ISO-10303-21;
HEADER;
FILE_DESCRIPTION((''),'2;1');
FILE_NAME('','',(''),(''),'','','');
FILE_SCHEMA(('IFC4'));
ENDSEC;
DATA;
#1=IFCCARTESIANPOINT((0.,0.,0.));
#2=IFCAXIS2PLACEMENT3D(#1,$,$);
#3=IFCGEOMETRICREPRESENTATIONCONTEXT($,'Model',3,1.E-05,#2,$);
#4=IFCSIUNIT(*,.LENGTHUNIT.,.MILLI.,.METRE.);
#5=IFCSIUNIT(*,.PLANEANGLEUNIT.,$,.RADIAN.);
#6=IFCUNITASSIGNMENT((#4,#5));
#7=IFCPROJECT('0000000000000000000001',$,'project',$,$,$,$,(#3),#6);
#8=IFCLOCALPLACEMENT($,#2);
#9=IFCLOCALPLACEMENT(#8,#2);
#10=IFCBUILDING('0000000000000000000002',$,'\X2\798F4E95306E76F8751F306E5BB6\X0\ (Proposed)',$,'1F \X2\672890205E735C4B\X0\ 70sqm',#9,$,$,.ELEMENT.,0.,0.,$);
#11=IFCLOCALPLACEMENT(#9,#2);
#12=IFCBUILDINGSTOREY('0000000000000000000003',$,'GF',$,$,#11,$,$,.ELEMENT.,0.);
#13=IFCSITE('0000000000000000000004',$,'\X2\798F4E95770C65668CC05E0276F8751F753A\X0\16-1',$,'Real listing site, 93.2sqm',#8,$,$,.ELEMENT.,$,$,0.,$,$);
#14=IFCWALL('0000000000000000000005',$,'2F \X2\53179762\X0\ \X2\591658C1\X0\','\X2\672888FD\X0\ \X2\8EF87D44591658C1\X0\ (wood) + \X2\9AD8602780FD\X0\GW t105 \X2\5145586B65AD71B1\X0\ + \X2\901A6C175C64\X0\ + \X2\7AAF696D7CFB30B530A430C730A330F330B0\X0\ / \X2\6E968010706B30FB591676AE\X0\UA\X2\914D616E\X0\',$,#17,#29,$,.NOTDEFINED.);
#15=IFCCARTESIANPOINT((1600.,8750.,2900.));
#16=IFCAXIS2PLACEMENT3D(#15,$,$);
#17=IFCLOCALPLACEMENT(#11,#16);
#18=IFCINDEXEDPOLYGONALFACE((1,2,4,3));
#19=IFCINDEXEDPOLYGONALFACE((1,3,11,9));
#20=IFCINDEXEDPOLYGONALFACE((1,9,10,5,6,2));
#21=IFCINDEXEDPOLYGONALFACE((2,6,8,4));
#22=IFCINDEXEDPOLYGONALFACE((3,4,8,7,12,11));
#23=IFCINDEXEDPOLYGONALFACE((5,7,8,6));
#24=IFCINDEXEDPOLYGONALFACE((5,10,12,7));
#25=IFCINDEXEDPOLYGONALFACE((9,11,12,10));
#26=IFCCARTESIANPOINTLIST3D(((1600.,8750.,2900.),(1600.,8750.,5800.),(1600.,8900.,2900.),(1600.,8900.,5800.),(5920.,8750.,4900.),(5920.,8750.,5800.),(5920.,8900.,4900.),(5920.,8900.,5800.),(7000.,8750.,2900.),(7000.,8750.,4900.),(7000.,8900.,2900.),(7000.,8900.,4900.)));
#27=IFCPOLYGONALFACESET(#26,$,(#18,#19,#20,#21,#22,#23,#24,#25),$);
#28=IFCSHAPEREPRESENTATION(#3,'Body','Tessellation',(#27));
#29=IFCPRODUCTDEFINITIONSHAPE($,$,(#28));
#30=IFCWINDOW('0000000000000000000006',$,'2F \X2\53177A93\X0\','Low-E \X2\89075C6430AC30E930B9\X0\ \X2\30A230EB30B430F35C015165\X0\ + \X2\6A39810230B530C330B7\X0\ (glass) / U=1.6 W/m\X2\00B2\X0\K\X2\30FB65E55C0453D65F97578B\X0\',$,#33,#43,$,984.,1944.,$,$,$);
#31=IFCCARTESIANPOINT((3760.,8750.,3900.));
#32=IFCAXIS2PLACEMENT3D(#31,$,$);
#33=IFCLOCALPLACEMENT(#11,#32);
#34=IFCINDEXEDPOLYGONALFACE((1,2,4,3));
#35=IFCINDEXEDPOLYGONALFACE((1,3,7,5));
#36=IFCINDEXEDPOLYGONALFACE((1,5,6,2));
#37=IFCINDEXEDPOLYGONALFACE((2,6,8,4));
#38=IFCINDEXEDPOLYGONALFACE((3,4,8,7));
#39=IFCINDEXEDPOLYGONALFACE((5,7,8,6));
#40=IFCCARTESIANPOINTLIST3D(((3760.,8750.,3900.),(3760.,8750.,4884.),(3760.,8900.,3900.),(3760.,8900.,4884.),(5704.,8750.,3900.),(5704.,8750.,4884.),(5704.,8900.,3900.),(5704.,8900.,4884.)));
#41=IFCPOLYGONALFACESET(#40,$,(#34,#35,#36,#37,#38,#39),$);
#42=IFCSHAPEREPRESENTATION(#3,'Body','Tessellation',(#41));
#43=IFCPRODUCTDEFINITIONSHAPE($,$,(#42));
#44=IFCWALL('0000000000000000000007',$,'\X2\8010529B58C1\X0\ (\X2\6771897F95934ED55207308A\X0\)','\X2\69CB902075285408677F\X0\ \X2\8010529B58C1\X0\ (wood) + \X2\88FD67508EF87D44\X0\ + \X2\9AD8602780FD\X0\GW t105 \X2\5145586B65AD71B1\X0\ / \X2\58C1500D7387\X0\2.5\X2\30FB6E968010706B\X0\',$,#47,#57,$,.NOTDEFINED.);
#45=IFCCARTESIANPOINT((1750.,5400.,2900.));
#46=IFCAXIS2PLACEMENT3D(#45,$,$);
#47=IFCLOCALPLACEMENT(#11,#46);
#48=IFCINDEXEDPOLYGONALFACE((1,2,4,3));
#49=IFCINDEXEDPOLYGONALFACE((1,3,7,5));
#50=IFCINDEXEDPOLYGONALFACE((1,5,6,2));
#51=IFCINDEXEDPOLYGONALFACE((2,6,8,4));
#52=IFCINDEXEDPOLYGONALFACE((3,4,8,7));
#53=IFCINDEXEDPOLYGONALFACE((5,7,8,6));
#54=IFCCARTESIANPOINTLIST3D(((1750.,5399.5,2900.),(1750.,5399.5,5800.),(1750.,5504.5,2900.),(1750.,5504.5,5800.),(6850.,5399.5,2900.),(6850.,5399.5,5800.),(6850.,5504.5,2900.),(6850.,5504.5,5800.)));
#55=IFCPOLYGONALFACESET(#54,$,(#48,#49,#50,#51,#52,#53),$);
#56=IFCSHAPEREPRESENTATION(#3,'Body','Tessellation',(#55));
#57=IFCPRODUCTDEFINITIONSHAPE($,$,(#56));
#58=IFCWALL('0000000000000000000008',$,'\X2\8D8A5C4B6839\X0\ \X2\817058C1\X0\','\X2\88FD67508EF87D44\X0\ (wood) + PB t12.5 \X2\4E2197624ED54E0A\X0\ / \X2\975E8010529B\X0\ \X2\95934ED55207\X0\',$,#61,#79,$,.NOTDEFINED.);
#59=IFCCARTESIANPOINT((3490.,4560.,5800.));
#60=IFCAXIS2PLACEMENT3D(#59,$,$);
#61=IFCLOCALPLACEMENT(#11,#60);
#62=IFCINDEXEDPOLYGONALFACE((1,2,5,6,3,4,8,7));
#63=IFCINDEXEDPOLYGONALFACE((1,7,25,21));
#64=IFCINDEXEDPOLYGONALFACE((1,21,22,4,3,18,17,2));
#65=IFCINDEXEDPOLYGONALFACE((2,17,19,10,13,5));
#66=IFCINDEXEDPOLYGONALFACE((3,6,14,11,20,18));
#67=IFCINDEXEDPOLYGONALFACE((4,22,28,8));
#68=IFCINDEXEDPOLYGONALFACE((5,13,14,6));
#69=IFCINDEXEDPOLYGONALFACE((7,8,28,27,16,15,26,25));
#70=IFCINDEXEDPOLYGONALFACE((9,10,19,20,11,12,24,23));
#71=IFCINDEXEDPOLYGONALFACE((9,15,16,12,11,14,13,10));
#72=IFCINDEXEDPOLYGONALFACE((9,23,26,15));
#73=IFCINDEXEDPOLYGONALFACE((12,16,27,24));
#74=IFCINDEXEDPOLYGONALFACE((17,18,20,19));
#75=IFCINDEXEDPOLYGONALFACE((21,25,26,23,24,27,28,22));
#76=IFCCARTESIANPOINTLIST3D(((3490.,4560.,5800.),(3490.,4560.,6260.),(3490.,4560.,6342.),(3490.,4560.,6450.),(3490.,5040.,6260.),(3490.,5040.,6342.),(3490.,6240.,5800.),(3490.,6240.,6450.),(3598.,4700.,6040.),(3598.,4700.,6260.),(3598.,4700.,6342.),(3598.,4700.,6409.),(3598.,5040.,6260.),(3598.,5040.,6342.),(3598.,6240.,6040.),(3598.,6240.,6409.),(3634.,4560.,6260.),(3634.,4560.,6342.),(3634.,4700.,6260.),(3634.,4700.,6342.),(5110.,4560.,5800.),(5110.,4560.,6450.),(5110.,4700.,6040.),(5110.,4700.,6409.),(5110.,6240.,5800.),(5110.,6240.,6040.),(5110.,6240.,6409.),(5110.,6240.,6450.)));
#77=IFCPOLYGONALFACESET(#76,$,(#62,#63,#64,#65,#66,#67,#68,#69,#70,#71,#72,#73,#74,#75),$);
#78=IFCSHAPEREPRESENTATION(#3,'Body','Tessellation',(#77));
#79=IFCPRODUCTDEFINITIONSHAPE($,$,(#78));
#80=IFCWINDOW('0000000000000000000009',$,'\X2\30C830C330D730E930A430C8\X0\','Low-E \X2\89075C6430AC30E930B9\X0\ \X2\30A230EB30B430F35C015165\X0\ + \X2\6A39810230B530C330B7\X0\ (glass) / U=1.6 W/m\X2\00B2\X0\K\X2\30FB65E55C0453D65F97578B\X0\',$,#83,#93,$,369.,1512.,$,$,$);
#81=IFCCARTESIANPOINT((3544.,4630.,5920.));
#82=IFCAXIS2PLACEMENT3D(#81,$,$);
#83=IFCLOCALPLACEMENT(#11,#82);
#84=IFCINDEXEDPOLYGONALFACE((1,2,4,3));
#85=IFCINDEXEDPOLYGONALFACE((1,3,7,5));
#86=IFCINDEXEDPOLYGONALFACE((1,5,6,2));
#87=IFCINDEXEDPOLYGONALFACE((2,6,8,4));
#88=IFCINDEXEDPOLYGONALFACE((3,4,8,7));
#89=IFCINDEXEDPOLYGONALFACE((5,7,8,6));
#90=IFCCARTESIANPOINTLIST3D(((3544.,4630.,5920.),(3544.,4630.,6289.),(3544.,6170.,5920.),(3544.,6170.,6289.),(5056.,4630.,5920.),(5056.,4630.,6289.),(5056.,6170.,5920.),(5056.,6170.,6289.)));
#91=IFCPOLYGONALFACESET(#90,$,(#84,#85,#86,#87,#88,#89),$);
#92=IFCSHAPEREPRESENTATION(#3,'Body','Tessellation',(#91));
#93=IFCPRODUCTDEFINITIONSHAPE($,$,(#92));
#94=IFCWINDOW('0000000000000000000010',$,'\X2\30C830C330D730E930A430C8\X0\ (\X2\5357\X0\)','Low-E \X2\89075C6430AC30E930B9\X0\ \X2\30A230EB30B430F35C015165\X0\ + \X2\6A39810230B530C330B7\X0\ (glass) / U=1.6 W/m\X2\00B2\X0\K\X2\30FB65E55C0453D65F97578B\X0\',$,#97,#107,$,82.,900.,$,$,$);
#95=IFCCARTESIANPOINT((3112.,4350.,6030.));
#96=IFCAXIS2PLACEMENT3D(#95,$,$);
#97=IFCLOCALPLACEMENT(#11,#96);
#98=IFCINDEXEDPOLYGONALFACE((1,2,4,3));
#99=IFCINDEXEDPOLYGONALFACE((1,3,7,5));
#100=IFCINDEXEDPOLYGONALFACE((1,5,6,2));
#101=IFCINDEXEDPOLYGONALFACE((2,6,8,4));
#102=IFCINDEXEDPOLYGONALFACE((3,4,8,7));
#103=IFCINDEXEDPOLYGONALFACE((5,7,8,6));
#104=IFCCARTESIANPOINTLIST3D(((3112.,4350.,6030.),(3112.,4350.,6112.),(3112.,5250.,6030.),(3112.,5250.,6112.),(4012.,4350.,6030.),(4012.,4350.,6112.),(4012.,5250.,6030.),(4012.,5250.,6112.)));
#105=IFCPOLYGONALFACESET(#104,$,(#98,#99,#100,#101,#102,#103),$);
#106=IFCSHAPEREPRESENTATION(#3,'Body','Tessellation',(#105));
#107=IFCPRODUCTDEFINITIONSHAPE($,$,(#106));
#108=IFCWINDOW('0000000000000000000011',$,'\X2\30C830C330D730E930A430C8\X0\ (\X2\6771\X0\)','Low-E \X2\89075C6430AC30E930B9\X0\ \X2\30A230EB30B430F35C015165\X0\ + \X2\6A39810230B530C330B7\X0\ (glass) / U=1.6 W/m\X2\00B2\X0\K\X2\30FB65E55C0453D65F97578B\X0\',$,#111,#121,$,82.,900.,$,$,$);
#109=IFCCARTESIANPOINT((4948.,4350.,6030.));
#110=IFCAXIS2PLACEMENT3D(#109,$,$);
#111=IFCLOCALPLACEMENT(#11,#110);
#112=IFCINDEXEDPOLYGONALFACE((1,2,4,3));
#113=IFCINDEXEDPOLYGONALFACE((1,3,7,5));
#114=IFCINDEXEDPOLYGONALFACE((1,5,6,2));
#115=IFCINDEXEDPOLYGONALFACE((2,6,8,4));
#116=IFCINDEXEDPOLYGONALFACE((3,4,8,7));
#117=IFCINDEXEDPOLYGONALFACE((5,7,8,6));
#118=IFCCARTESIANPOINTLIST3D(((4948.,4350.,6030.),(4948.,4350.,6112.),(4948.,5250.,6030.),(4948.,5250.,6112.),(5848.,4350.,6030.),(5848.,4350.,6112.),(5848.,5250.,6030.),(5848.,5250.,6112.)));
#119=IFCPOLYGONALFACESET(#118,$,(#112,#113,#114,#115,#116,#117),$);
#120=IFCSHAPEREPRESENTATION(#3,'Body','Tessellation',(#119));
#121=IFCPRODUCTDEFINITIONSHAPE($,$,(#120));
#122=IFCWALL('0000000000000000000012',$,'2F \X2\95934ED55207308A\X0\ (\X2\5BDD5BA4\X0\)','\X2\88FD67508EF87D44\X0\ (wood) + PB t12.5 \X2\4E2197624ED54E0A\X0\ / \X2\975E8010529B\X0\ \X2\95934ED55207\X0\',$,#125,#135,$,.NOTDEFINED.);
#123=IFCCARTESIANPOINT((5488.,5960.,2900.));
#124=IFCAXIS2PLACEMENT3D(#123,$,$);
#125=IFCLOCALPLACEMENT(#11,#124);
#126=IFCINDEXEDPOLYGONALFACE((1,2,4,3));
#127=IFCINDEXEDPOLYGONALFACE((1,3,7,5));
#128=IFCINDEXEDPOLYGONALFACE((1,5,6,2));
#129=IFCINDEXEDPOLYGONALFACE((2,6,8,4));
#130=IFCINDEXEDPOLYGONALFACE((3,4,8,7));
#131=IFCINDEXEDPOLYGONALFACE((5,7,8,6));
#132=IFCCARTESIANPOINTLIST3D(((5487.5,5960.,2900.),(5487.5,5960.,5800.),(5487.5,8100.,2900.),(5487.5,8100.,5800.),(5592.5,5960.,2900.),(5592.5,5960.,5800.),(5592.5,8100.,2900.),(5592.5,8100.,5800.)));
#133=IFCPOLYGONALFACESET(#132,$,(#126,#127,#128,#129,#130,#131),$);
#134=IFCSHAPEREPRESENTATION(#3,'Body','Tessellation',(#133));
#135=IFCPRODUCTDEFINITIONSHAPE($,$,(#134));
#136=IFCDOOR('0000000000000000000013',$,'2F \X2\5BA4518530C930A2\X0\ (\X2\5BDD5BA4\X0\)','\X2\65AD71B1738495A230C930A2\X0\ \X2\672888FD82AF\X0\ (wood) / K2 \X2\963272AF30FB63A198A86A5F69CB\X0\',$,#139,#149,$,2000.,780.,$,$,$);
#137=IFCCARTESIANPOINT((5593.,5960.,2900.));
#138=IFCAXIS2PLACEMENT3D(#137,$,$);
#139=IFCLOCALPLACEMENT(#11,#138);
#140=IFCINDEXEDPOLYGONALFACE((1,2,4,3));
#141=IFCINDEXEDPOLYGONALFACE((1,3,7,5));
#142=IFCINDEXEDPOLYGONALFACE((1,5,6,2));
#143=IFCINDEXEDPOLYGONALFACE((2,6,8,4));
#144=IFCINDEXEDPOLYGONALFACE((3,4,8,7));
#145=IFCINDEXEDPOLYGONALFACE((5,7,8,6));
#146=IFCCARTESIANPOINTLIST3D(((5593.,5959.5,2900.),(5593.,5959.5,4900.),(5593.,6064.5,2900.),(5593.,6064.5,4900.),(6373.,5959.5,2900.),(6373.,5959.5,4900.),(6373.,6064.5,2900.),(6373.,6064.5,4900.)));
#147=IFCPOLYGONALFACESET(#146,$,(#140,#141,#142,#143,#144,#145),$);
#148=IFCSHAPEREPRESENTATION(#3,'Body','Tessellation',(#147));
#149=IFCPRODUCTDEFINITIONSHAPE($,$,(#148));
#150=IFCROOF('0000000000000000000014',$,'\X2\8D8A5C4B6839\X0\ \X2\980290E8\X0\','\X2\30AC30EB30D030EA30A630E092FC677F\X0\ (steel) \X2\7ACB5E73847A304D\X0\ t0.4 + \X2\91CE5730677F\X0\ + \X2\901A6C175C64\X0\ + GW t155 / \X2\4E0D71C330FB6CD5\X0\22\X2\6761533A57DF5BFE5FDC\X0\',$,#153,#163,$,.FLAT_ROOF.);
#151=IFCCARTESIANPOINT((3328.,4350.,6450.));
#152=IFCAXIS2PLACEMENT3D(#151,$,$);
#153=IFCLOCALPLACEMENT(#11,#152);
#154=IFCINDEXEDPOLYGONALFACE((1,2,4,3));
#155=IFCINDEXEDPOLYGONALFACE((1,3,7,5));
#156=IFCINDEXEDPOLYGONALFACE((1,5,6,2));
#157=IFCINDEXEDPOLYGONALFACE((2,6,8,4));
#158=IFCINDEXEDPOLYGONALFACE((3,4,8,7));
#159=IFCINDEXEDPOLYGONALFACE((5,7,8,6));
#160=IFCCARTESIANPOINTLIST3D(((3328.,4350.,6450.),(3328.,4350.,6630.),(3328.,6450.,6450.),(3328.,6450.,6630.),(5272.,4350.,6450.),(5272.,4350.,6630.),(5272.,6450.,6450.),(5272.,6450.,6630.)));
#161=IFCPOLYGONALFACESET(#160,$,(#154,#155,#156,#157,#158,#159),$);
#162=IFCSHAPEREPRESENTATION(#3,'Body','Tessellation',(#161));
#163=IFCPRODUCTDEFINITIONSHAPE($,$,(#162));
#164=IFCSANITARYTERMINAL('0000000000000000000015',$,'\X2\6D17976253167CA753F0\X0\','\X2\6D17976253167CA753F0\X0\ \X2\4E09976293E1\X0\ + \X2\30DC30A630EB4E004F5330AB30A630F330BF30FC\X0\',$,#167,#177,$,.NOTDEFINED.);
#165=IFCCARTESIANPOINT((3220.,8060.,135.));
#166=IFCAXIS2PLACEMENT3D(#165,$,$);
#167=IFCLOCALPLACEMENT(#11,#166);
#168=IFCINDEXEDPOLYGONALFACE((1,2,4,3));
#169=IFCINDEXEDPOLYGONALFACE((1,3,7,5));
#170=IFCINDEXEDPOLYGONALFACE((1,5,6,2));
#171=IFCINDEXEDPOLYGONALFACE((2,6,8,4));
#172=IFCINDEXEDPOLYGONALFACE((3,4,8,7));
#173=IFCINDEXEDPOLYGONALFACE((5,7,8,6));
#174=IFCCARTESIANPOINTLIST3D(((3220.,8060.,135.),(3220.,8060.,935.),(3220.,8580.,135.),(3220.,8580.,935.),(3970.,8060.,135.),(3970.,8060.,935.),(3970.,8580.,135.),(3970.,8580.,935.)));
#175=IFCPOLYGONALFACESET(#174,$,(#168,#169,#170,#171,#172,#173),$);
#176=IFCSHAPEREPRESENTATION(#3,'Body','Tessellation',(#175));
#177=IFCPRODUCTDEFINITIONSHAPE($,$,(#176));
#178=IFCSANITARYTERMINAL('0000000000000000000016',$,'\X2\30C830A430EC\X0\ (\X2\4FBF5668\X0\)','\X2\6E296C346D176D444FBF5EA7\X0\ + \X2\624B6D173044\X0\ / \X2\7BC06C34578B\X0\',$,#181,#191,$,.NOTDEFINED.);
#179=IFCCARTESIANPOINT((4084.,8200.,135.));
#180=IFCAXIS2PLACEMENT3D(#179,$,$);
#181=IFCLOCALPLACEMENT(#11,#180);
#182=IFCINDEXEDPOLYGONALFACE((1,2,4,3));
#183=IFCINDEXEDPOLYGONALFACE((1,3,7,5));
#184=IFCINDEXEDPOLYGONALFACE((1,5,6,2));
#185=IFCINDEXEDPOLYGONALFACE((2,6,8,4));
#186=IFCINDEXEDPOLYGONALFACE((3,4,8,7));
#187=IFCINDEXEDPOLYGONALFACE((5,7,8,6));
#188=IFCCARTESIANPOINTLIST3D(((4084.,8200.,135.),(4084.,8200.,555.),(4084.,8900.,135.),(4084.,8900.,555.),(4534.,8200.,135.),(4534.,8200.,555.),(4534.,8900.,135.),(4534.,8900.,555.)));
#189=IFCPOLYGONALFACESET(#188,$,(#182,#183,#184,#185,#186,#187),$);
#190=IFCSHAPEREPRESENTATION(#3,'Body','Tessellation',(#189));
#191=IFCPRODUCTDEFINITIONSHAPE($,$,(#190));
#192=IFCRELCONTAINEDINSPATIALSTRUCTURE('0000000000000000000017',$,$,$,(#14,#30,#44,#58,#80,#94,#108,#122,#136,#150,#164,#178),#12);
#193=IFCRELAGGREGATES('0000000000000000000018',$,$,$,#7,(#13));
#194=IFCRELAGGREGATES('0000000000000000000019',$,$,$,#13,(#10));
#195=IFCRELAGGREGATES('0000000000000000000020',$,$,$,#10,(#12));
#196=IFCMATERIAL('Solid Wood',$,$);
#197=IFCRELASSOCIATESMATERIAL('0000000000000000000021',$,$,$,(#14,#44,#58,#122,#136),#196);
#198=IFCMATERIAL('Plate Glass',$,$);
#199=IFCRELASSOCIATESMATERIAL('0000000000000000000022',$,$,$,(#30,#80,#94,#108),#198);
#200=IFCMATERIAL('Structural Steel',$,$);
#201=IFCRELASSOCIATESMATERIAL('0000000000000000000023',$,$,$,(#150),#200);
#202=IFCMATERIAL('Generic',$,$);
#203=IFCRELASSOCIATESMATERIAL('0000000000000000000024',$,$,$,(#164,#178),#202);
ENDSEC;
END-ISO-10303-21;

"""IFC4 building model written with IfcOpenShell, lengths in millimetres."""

from ifc_helpers import new_model, si_unit, frame, frame_2d, origin, place, context, project, spatial, rectangle, extrude, material, element, fill, save


model = new_model("IFC4")

# Units and contexts
model_context = context("Model", 3, precision=1e-05, world=origin())
ifc_project = project(units=[si_unit("LENGTHUNIT", "METRE", prefix="MILLI"), si_unit("PLANEANGLEUNIT", "RADIAN")], contexts=[model_context])

# Site, building, storey
site_placement = place(None, origin())
site = spatial("IfcSite", under=ifc_project, at=site_placement, Name="福井県敦賀市相生町16-1", ObjectType="Real listing site, 93.2sqm", CompositionType="ELEMENT", RefElevation=0.0)
building_placement = place(site_placement, origin())
building = spatial("IfcBuilding", under=site, at=building_placement, Name="福井の相生の家 (Proposed)", ObjectType="1F 木造平屋 70sqm", CompositionType="ELEMENT", ElevationOfRefHeight=0.0, ElevationOfTerrain=0.0)
storey_placement = place(building_placement, origin())
storey = spatial("IfcBuildingStorey", under=building, at=storey_placement, Name="GF", CompositionType="ELEMENT", Elevation=0.0)

# Wall, opening, window
ifc_material_1 = material(Name="Solid Wood")
wall_1_placement = place(storey_placement, frame((1600.0, 8750.0, 2900.0)))
wall_1 = element("IfcWall", 1, at=wall_1_placement, inside=storey, material=ifc_material_1, Name="2F 北面 外壁", Description="木製 軸組外壁 (wood) + 高性能GW t105 充填断熱 + 通気層 + 窯業系サイディング / 準耐火・外皮UA配慮", PredefinedType="NOTDEFINED", context=model_context, shape_type="SweptSolid", body=[
    extrude(rectangle(XDim=5400.0, YDim=150.0, at=frame_2d((2700.0, 75.0))), frame((1600.0, 8750.0, 2900.0)), (0.0, 0.0, 1.0), 2900.0),
])
opening_1_placement = place(storey_placement, frame((3760.0, 8750.0, 3900.0)))
opening_1 = element("IfcOpeningElement", 2, at=opening_1_placement, cuts=wall_1, PredefinedType="NOTDEFINED", context=model_context, shape_type="SweptSolid", body=[
    extrude(rectangle(XDim=1944.0, YDim=150.0, at=frame_2d((972.0, 75.0))), frame((3760.0, 8750.0, 3900.0)), (0.0, 0.0, 1.0), 984.0),
])
ifc_material_2 = material(Name="Plate Glass")
window_1_placement = place(storey_placement, frame((3760.0, 8750.0, 3900.0)))
window_1 = element("IfcWindow", 3, at=window_1_placement, inside=storey, material=ifc_material_2, Name="2F 北窓", Description="Low-E 複層ガラス アルゴン封入 + 樹脂サッシ (glass) / U=1.6 W/m²K・日射取得型", OverallHeight=984.0, OverallWidth=1944.0, context=model_context, shape_type="SweptSolid", body=[
    extrude(rectangle(XDim=1944.0, YDim=150.0, at=frame_2d((972.0, 75.0))), frame((3760.0, 8750.0, 3900.0)), (0.0, 0.0, 1.0), 984.0),
])
fill(opening_1, window_1)

# Wall
wall_2_placement = place(storey_placement, frame((1750.0, 5400.0, 2900.0)))
element("IfcWall", 4, at=wall_2_placement, inside=storey, material=ifc_material_1, Name="耐力壁 (東西間仕切り)", Description="構造用合板 耐力壁 (wood) + 製材軸組 + 高性能GW t105 充填断熱 / 壁倍率2.5・準耐火", PredefinedType="NOTDEFINED", context=model_context, shape_type="SweptSolid", body=[
    extrude(rectangle(XDim=5100.0, YDim=105.0, at=frame_2d((2550.0, 52.0))), frame((1750.0, 5400.0, 2900.0)), (0.0, 0.0, 1.0), 2900.0),
])

# Wall, openings, windows
wall_3_placement = place(storey_placement, frame((3490.0, 4560.0, 5800.0)))
wall_3 = element("IfcWall", 5, at=wall_3_placement, inside=storey, material=ifc_material_1, Name="越屋根 腰壁", Description="製材軸組 (wood) + PB t12.5 両面仕上 / 非耐力 間仕切", PredefinedType="NOTDEFINED", context=model_context, shape_type="SweptSolid", body=[
    extrude(rectangle(XDim=1620.0, YDim=1680.0, at=frame_2d((810.0, 840.0))), frame((3490.0, 4560.0, 5800.0)), (0.0, 0.0, 1.0), 650.0),
])
opening_2_placement = place(storey_placement, frame((3544.0, 4630.0, 5920.0)))
opening_2 = element("IfcOpeningElement", 6, at=opening_2_placement, cuts=wall_3, PredefinedType="NOTDEFINED", context=model_context, shape_type="SweptSolid", body=[
    extrude(rectangle(XDim=1512.0, YDim=1540.0, at=frame_2d((756.0, 770.0))), frame((3544.0, 4630.0, 5920.0)), (0.0, 0.0, 1.0), 369.0),
])
opening_3_placement = place(storey_placement, frame((3112.0, 4350.0, 6030.0)))
opening_3 = element("IfcOpeningElement", 7, at=opening_3_placement, cuts=wall_3, PredefinedType="NOTDEFINED", context=model_context, shape_type="SweptSolid", body=[
    extrude(rectangle(XDim=900.0, YDim=900.0, at=frame_2d((450.0, 450.0))), frame((3112.0, 4350.0, 6030.0)), (0.0, 0.0, 1.0), 82.0),
])
opening_4_placement = place(storey_placement, frame((4948.0, 4350.0, 6030.0)))
opening_4 = element("IfcOpeningElement", 8, at=opening_4_placement, cuts=wall_3, PredefinedType="NOTDEFINED", context=model_context, shape_type="SweptSolid", body=[
    extrude(rectangle(XDim=900.0, YDim=900.0, at=frame_2d((450.0, 450.0))), frame((4948.0, 4350.0, 6030.0)), (0.0, 0.0, 1.0), 82.0),
])
window_2_placement = place(storey_placement, frame((3544.0, 4630.0, 5920.0)))
window_2 = element("IfcWindow", 9, at=window_2_placement, inside=storey, material=ifc_material_2, Name="トップライト", Description="Low-E 複層ガラス アルゴン封入 + 樹脂サッシ (glass) / U=1.6 W/m²K・日射取得型", OverallHeight=369.0, OverallWidth=1512.0, context=model_context, shape_type="SweptSolid", body=[
    extrude(rectangle(XDim=1512.0, YDim=1540.0, at=frame_2d((756.0, 770.0))), frame((3544.0, 4630.0, 5920.0)), (0.0, 0.0, 1.0), 369.0),
])
fill(opening_2, window_2)
window_3_placement = place(storey_placement, frame((3112.0, 4350.0, 6030.0)))
window_3 = element("IfcWindow", 10, at=window_3_placement, inside=storey, material=ifc_material_2, Name="トップライト (南)", Description="Low-E 複層ガラス アルゴン封入 + 樹脂サッシ (glass) / U=1.6 W/m²K・日射取得型", OverallHeight=82.0, OverallWidth=900.0, context=model_context, shape_type="SweptSolid", body=[
    extrude(rectangle(XDim=900.0, YDim=900.0, at=frame_2d((450.0, 450.0))), frame((3112.0, 4350.0, 6030.0)), (0.0, 0.0, 1.0), 82.0),
])
fill(opening_3, window_3)
window_4_placement = place(storey_placement, frame((4948.0, 4350.0, 6030.0)))
window_4 = element("IfcWindow", 11, at=window_4_placement, inside=storey, material=ifc_material_2, Name="トップライト (東)", Description="Low-E 複層ガラス アルゴン封入 + 樹脂サッシ (glass) / U=1.6 W/m²K・日射取得型", OverallHeight=82.0, OverallWidth=900.0, context=model_context, shape_type="SweptSolid", body=[
    extrude(rectangle(XDim=900.0, YDim=900.0, at=frame_2d((450.0, 450.0))), frame((4948.0, 4350.0, 6030.0)), (0.0, 0.0, 1.0), 82.0),
])
fill(opening_4, window_4)

# Wall
wall_4_placement = place(storey_placement, frame((5488.0, 5960.0, 2900.0)))
element("IfcWall", 12, at=wall_4_placement, inside=storey, material=ifc_material_1, Name="2F 間仕切り (寝室)", Description="製材軸組 (wood) + PB t12.5 両面仕上 / 非耐力 間仕切", PredefinedType="NOTDEFINED", context=model_context, shape_type="SweptSolid", body=[
    extrude(rectangle(XDim=105.0, YDim=2140.0, at=frame_2d((52.0, 1070.0))), frame((5488.0, 5960.0, 2900.0)), (0.0, 0.0, 1.0), 2900.0),
])

# Door
door_placement = place(storey_placement, frame((5593.0, 5960.0, 2900.0)))
element("IfcDoor", 13, at=door_placement, inside=storey, material=ifc_material_1, Name="2F 室内ドア (寝室)", Description="断熱玄関ドア 木製芯 (wood) / K2 防犯・採風機構", OverallHeight=2000.0, OverallWidth=780.0, context=model_context, shape_type="SweptSolid", body=[
    extrude(rectangle(XDim=780.0, YDim=105.0, at=frame_2d((390.0, 52.0))), frame((5593.0, 5960.0, 2900.0)), (0.0, 0.0, 1.0), 2000.0),
])

# Roof
ifc_material_3 = material(Name="Structural Steel")
roof_placement = place(storey_placement, frame((3328.0, 4350.0, 6450.0)))
element("IfcRoof", 14, at=roof_placement, inside=storey, material=ifc_material_3, Name="越屋根 頂部", Description="ガルバリウム鋼板 (steel) 立平葺き t0.4 + 野地板 + 通気層 + GW t155 / 不燃・法22条区域対応", PredefinedType="FLAT_ROOF", context=model_context, shape_type="SweptSolid", body=[
    extrude(rectangle(XDim=1944.0, YDim=2100.0, at=frame_2d((972.0, 1050.0))), frame((3328.0, 4350.0, 6450.0)), (0.0, 0.0, 1.0), 180.0),
])

# Sanitary terminals
ifc_material_4 = material(Name="Generic")
sanitary_terminal_1_placement = place(storey_placement, frame((3220.0, 8060.0, 135.0)))
element("IfcSanitaryTerminal", 15, at=sanitary_terminal_1_placement, inside=storey, material=ifc_material_4, Name="洗面化粧台", Description="洗面化粧台 三面鏡 + ボウル一体カウンター", PredefinedType="NOTDEFINED", context=model_context, shape_type="SweptSolid", body=[
    extrude(rectangle(XDim=750.0, YDim=520.0, at=frame_2d((375.0, 260.0))), frame((3220.0, 8060.0, 135.0)), (0.0, 0.0, 1.0), 800.0),
])
sanitary_terminal_2_placement = place(storey_placement, frame((4084.0, 8200.0, 135.0)))
element("IfcSanitaryTerminal", 16, at=sanitary_terminal_2_placement, inside=storey, material=ifc_material_4, Name="トイレ (便器)", Description="温水洗浄便座 + 手洗い / 節水型", PredefinedType="NOTDEFINED", context=model_context, shape_type="SweptSolid", body=[
    extrude(rectangle(XDim=450.0, YDim=700.0, at=frame_2d((225.0, 350.0))), frame((4084.0, 8200.0, 135.0)), (0.0, 0.0, 1.0), 420.0),
])

save(model, "model.ifc")
